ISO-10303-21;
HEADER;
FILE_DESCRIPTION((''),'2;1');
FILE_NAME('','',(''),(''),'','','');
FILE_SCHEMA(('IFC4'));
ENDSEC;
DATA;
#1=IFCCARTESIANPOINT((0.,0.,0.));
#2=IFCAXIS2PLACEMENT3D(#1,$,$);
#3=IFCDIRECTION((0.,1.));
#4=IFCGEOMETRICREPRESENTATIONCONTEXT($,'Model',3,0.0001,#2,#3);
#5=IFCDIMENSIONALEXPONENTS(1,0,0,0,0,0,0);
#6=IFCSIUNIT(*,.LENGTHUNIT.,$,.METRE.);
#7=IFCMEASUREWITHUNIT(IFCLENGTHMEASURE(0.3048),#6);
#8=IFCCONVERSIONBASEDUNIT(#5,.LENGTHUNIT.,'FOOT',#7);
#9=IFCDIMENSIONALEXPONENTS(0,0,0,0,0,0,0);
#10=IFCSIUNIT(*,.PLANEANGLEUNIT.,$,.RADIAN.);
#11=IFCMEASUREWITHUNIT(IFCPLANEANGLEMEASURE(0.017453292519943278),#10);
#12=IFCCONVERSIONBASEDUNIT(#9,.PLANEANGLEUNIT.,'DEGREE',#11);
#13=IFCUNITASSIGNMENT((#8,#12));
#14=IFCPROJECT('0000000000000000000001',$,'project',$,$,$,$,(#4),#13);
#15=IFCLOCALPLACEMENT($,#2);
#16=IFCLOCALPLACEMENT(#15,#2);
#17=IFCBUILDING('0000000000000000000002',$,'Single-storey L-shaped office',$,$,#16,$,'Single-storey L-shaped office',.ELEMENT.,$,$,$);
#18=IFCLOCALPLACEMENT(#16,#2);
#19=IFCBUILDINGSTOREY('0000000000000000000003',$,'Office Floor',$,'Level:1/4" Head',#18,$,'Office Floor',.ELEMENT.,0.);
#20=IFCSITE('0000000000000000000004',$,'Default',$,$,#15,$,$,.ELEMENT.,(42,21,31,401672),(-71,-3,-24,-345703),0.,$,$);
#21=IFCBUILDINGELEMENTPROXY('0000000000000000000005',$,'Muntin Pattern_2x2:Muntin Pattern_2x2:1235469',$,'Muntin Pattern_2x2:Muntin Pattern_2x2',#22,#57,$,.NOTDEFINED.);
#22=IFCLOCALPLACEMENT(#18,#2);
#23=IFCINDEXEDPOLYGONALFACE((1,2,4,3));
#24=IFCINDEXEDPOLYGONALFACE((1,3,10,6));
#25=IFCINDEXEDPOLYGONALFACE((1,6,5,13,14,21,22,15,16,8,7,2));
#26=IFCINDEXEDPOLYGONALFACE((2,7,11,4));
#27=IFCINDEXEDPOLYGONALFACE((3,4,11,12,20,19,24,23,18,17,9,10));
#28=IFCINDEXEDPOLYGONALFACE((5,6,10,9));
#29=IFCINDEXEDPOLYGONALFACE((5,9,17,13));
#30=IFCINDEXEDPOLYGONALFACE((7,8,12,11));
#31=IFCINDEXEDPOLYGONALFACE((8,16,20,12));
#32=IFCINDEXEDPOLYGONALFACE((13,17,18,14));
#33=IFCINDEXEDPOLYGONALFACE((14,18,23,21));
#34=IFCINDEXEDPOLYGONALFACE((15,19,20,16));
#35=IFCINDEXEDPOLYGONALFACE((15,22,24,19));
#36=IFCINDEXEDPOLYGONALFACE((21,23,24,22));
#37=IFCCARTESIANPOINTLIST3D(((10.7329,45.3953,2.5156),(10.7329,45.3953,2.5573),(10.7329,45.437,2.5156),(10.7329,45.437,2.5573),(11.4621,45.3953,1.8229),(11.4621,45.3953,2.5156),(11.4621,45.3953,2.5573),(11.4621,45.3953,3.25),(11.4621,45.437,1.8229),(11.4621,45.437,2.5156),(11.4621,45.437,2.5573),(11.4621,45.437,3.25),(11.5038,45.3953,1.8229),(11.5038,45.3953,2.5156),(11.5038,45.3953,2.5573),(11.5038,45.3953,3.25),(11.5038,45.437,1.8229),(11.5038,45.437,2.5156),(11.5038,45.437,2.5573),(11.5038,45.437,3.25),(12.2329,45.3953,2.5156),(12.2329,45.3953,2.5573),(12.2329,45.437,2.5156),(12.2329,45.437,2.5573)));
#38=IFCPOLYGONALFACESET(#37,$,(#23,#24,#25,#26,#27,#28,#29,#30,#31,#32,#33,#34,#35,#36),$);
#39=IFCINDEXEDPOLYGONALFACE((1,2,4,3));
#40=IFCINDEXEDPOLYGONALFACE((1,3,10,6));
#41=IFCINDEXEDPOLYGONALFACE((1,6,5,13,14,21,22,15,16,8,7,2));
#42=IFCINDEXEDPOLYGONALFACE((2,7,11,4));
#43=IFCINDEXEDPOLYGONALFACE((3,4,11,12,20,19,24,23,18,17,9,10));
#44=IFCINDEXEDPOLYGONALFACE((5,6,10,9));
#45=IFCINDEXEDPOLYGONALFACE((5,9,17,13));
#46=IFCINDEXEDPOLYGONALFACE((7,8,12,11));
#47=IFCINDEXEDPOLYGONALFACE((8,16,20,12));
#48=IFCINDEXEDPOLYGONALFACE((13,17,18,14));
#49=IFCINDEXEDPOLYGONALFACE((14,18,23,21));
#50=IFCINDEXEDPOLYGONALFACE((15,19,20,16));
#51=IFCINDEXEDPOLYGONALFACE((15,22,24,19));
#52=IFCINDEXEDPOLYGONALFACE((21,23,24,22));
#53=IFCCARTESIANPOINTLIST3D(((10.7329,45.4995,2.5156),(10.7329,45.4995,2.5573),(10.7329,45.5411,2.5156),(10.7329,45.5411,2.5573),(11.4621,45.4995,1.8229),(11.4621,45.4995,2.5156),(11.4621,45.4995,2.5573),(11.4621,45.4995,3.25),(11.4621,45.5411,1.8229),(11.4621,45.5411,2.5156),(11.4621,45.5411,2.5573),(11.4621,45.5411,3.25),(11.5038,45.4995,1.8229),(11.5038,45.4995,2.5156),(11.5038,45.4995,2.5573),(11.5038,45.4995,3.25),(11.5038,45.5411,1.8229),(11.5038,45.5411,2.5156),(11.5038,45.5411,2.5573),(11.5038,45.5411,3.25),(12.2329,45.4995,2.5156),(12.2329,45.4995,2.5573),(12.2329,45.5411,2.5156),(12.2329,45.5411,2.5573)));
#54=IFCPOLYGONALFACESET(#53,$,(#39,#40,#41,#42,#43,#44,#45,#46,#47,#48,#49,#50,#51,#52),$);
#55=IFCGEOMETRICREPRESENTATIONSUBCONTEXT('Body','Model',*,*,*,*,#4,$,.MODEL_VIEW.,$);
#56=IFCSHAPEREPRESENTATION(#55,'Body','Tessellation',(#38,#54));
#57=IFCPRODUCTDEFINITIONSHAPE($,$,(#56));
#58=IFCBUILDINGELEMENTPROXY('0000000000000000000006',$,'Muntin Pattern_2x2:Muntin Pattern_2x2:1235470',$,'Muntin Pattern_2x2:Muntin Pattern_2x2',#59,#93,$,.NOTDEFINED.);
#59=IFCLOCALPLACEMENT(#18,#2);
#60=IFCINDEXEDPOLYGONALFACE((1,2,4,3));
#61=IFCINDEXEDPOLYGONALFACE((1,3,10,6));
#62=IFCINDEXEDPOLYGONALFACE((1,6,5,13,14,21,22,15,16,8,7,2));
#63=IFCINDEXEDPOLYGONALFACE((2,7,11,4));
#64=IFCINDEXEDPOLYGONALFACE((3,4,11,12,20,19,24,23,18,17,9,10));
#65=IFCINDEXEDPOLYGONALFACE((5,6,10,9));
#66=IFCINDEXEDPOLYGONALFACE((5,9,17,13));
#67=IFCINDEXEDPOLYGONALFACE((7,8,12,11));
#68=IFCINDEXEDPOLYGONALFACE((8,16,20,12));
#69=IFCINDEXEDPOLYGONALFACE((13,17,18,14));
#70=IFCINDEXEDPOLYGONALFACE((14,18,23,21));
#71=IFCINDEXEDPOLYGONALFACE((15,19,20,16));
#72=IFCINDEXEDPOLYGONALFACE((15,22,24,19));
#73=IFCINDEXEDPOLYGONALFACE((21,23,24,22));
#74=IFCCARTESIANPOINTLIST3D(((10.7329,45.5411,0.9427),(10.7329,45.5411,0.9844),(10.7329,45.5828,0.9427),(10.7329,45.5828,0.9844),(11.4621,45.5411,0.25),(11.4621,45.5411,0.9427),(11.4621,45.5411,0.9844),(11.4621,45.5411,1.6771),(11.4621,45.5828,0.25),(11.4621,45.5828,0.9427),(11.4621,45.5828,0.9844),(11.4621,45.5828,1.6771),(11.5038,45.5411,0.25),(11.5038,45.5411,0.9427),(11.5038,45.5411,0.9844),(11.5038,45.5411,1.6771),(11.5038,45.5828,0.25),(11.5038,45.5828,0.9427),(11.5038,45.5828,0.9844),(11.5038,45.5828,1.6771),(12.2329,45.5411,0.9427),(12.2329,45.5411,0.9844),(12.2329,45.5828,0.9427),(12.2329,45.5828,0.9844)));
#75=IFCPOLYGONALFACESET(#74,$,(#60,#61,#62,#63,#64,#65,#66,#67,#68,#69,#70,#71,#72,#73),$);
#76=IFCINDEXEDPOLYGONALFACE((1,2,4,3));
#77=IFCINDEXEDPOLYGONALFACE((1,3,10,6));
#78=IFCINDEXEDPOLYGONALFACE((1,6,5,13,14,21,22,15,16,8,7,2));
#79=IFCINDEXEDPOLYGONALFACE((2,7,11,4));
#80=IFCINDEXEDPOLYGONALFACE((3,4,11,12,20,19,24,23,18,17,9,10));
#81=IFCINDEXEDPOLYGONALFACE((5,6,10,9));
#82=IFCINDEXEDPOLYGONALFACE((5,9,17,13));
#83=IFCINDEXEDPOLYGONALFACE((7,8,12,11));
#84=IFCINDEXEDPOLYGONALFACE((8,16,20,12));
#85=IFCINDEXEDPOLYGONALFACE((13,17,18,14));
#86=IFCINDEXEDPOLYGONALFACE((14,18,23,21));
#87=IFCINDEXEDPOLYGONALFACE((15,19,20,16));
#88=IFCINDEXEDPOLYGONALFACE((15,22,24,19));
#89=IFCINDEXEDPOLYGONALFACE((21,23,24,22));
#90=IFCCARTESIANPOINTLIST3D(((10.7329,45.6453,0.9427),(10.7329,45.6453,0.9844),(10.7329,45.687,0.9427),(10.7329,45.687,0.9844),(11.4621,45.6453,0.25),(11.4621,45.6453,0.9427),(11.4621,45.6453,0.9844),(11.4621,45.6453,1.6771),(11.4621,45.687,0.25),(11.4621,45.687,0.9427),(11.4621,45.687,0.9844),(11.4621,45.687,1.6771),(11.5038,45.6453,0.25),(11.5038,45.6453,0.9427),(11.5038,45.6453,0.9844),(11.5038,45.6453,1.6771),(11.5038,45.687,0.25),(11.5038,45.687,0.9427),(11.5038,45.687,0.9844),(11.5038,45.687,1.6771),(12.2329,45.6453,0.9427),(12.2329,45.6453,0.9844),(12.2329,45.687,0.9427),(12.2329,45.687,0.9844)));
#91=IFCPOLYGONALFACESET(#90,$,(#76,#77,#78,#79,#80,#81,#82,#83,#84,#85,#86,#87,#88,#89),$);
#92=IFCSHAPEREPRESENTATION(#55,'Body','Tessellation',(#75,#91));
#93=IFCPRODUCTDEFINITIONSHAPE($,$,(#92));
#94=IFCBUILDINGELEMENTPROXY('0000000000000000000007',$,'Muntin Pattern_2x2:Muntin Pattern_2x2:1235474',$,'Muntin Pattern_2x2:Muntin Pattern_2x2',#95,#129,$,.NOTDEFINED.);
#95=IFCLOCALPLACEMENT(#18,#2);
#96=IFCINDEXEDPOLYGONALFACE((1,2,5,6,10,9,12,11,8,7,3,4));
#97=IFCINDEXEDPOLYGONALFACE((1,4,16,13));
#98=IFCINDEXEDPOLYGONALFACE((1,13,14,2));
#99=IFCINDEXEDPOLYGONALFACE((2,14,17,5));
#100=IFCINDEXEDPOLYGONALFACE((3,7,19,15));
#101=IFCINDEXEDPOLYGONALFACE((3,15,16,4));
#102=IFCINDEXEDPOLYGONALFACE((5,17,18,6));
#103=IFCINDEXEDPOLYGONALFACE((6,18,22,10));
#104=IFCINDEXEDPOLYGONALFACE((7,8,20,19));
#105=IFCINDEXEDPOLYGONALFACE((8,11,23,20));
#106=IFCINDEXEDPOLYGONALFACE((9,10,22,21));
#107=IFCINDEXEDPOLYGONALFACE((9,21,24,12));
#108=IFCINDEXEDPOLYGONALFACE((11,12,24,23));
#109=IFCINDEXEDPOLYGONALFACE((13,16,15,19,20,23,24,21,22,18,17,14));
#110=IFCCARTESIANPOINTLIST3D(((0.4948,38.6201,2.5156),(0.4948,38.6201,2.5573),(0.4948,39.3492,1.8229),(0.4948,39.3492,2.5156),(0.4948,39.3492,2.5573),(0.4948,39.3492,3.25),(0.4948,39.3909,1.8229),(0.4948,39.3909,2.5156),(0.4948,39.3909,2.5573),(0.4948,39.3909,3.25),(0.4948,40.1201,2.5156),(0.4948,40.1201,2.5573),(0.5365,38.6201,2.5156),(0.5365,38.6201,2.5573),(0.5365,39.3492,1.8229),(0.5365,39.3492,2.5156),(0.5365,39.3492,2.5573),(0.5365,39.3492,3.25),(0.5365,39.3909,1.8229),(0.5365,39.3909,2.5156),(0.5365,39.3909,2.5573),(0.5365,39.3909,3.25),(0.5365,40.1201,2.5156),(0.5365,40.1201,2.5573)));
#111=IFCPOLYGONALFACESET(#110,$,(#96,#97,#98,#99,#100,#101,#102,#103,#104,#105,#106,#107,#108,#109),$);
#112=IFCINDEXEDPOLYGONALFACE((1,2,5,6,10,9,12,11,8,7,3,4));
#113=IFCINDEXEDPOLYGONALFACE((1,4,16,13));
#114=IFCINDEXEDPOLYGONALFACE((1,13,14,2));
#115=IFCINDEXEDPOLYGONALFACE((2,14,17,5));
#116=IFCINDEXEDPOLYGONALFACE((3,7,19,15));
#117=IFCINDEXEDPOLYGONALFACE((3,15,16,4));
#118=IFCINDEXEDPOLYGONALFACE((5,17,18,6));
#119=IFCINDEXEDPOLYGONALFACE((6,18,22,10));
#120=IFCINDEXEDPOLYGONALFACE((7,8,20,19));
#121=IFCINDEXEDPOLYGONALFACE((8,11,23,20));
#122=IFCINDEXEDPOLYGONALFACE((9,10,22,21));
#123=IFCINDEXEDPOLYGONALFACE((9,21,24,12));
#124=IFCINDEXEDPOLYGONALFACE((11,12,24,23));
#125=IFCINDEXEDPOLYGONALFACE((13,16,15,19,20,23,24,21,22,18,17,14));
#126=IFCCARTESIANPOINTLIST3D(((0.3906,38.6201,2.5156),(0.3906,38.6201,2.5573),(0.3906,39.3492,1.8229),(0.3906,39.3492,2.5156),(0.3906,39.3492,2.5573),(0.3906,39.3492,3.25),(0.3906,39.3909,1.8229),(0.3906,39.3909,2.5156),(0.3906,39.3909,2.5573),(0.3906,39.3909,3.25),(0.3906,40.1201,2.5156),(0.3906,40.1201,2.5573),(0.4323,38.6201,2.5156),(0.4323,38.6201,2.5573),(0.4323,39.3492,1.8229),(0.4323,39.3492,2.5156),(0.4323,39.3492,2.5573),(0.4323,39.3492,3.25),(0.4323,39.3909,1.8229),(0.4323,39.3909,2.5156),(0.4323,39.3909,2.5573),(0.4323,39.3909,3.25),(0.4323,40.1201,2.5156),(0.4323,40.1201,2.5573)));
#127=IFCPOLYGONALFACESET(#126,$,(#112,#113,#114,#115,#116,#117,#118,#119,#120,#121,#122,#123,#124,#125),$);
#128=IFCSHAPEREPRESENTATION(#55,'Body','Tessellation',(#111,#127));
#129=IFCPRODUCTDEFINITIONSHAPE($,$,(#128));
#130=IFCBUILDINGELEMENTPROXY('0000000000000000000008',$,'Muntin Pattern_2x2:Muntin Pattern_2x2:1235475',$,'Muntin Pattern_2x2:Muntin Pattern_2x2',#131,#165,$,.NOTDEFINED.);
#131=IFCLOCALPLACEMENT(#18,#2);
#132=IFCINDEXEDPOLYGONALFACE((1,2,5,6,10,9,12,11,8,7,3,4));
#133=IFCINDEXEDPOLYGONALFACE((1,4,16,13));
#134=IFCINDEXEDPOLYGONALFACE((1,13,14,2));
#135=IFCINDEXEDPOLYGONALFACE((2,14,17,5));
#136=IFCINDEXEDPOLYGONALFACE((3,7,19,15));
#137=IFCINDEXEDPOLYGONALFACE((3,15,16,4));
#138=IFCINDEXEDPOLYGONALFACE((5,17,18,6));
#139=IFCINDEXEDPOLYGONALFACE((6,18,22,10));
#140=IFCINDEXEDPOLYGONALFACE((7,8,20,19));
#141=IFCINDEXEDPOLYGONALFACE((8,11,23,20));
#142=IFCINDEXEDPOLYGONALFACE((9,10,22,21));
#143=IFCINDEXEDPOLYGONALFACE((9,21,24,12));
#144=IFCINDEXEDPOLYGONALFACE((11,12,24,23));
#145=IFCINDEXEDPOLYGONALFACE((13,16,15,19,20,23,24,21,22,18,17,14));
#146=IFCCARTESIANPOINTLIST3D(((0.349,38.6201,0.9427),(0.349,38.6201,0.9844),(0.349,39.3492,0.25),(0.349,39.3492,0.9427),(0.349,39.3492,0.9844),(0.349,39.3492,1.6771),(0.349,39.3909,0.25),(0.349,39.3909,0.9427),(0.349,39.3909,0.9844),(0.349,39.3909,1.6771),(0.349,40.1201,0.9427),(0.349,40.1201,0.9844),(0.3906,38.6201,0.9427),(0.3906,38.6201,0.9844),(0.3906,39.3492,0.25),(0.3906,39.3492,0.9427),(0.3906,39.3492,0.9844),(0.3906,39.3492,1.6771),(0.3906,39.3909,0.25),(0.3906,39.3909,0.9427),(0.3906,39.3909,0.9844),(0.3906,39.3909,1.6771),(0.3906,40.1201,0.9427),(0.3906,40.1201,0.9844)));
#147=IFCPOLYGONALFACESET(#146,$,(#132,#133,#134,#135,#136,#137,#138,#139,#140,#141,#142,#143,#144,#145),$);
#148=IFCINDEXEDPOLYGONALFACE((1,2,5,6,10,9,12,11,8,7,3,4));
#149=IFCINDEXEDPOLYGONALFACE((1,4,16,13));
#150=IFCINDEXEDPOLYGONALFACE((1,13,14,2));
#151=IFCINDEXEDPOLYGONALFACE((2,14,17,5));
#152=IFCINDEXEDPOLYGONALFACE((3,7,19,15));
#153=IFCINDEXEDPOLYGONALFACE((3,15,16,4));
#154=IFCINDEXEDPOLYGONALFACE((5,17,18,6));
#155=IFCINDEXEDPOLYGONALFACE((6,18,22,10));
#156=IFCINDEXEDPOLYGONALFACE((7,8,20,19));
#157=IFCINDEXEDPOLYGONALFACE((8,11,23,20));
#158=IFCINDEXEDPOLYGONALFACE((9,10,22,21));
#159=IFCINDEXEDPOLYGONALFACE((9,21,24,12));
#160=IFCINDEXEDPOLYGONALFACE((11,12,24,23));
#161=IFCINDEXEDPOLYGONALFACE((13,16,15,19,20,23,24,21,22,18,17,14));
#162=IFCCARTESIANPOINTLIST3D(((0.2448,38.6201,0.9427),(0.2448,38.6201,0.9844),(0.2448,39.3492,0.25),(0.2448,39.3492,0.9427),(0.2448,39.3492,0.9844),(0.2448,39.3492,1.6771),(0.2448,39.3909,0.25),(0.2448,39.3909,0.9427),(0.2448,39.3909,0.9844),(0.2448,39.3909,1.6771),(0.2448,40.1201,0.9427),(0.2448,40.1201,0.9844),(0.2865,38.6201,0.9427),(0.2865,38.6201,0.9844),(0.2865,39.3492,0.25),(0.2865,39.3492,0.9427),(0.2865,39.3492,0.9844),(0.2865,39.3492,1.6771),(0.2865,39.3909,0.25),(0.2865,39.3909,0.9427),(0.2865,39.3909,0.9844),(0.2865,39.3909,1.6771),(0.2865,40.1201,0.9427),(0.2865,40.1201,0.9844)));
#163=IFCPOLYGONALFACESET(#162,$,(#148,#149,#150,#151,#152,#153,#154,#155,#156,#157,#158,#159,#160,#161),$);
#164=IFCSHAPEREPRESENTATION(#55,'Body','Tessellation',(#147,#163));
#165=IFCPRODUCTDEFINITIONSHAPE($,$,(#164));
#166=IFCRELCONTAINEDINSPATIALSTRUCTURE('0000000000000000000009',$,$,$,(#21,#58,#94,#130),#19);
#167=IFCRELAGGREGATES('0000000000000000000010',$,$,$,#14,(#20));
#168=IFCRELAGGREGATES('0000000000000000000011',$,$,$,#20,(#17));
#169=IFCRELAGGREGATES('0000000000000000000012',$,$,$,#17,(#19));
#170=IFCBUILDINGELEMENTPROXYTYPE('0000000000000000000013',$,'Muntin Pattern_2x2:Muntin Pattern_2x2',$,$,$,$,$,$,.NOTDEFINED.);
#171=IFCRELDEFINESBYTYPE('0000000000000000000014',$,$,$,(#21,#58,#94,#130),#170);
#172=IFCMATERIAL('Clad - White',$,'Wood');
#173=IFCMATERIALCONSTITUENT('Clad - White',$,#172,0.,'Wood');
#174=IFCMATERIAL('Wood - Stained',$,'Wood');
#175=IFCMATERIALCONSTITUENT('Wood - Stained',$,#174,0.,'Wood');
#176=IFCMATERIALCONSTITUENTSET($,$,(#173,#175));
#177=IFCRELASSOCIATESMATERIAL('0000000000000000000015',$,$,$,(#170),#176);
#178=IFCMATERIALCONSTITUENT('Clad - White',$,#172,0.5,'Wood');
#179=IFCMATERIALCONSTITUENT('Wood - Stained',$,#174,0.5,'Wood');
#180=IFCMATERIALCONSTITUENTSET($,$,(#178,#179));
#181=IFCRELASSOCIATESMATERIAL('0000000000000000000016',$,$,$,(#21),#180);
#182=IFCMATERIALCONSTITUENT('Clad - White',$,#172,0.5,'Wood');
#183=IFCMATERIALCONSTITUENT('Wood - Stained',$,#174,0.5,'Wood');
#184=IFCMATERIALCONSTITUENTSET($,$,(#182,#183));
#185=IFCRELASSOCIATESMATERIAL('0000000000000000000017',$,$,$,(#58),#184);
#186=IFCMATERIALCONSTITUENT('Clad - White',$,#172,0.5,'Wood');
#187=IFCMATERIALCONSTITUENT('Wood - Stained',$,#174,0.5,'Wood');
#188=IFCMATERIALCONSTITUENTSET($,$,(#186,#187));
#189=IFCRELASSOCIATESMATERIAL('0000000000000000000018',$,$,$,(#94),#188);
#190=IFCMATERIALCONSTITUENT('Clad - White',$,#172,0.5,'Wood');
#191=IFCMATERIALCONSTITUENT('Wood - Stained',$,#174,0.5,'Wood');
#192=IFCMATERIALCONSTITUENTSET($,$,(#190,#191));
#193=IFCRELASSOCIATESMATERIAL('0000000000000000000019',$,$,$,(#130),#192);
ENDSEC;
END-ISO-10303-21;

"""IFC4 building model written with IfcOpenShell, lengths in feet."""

from ifc_helpers import new_model, entity, si_unit, converted_unit, direction, frame, origin, place, context, subcontext, project, spatial, indexed_curve, outline, extrude, source, transform, mapped, material, constituent, constituent_set, type_object, type_shapes, element, save


model = new_model("IFC4")

# Units and contexts
model_context = context("Model", 3, precision=0.0001, world=origin(), true_north=direction((0.0, 1.0)))
body_context = subcontext(model_context, "Body", "Model", "MODEL_VIEW")
ifc_project = project(units=[converted_unit("LENGTHUNIT", "FOOT", entity("IfcLengthMeasure", 0.3048), si_unit("LENGTHUNIT", "METRE"), dimensions=[1, 0, 0, 0, 0, 0, 0]), converted_unit("PLANEANGLEUNIT", "DEGREE", entity("IfcPlaneAngleMeasure", 0.017453292519943278), si_unit("PLANEANGLEUNIT", "RADIAN"), dimensions=[0, 0, 0, 0, 0, 0, 0])], contexts=[model_context])

# Site, building, storey
site_placement = place(None, origin())
site = spatial("IfcSite", under=ifc_project, at=site_placement, Name="Default", CompositionType="ELEMENT", RefLatitude=(42, 21, 31, 401672), RefLongitude=(-71, -3, -24, -345703), RefElevation=0.0)
building_placement = place(site_placement, origin())
building = spatial("IfcBuilding", under=site, at=building_placement, Name="Single-storey L-shaped office", LongName="Single-storey L-shaped office", CompositionType="ELEMENT")
storey_placement = place(building_placement, origin())
storey = spatial("IfcBuildingStorey", under=building, at=storey_placement, Name="Office Floor", ObjectType="Level:1/4\" Head", LongName="Office Floor", CompositionType="ELEMENT", Elevation=0.0)

# Shared definitions
ifc_material_1 = material(Name="Wood - Stained", Category="Wood")

# Building element proxies
ifc_material_2 = material(Name="Clad - White", Category="Wood")
ifc_constituent_1 = constituent(ifc_material_2, Name="Clad - White", Category="Wood", fraction=0.0)
ifc_constituent_2 = constituent(ifc_material_1, Name="Wood - Stained", Category="Wood", fraction=0.0)
ifc_constituent_set_1 = constituent_set(constituents=[ifc_constituent_1, ifc_constituent_2])
building_element_proxy_type_1 = type_object("IfcBuildingElementProxyType", Name="Muntin Pattern_2x2:Muntin Pattern_2x2", PredefinedType="NOTDEFINED", material=ifc_constituent_set_1)
shared_shape_1 = source(origin(), body_context, "Body", "SweptSolid", [
    extrude(outline(indexed_curve([(0.0208, -0.0208), (0.7135, -0.0208), (0.7135, 0.0208), (0.0208, 0.0208), (0.0208, 0.75), (-0.0208, 0.75), (-0.0208, 0.0208), (-0.7135, 0.0208), (-0.7135, -0.0208), (-0.0208, -0.0208), (-0.0208, -0.75), (0.0208, -0.75), (0.0208, -0.0208)], self_intersect=False)), frame((0.0, 0.0312, 0.7135), z_axis=(0.0, 1.0, 0.0), x_axis=(0.0, 0.0, 1.0)), (0.0, 0.0, 1.0), 0.0417),
    extrude(outline(indexed_curve([(0.0208, -0.0208), (0.7135, -0.0208), (0.7135, 0.0208), (0.0208, 0.0208), (0.0208, 0.75), (-0.0208, 0.75), (-0.0208, 0.0208), (-0.7135, 0.0208), (-0.7135, -0.0208), (-0.0208, -0.0208), (-0.0208, -0.75), (0.0208, -0.75), (0.0208, -0.0208)], self_intersect=False)), frame((0.0, -0.0729, 0.7135), z_axis=(0.0, 1.0, 0.0), x_axis=(0.0, 0.0, 1.0)), (0.0, 0.0, 1.0), 0.0417),
])
type_shapes(building_element_proxy_type_1, [shared_shape_1])
ifc_constituent_3 = constituent(ifc_material_2, Name="Clad - White", Category="Wood", fraction=0.5)
ifc_constituent_4 = constituent(ifc_material_1, Name="Wood - Stained", Category="Wood", fraction=0.5)
ifc_constituent_set_2 = constituent_set(constituents=[ifc_constituent_3, ifc_constituent_4])
proxy_1_placement = place(storey_placement, frame((11.4829, 45.4682, 1.8229), z_axis=(0.0, 0.0, 1.0), x_axis=(-1.0, 0.0, 0.0)))
element("IfcBuildingElementProxy", 1, at=proxy_1_placement, inside=storey, type_object=building_element_proxy_type_1, material=ifc_constituent_set_2, Name="Muntin Pattern_2x2:Muntin Pattern_2x2:1235469", ObjectType="Muntin Pattern_2x2:Muntin Pattern_2x2", PredefinedType="NOTDEFINED", context=body_context, shape_type="MappedRepresentation", body=[
    mapped(shared_shape_1, transform((0.0, 0.0, 0.0), scale=1.0)),
])
ifc_constituent_5 = constituent(ifc_material_2, Name="Clad - White", Category="Wood", fraction=0.5)
ifc_constituent_6 = constituent(ifc_material_1, Name="Wood - Stained", Category="Wood", fraction=0.5)
ifc_constituent_set_3 = constituent_set(constituents=[ifc_constituent_5, ifc_constituent_6])
proxy_2_placement = place(storey_placement, frame((11.4829, 45.6141, 0.25), z_axis=(0.0, 0.0, 1.0), x_axis=(-1.0, 0.0, 0.0)))
element("IfcBuildingElementProxy", 2, at=proxy_2_placement, inside=storey, type_object=building_element_proxy_type_1, material=ifc_constituent_set_3, Name="Muntin Pattern_2x2:Muntin Pattern_2x2:1235470", ObjectType="Muntin Pattern_2x2:Muntin Pattern_2x2", PredefinedType="NOTDEFINED", context=body_context, shape_type="MappedRepresentation", body=[
    mapped(shared_shape_1, transform((0.0, 0.0, 0.0), scale=1.0)),
])
ifc_constituent_7 = constituent(ifc_material_2, Name="Clad - White", Category="Wood", fraction=0.5)
ifc_constituent_8 = constituent(ifc_material_1, Name="Wood - Stained", Category="Wood", fraction=0.5)
ifc_constituent_set_4 = constituent_set(constituents=[ifc_constituent_7, ifc_constituent_8])
proxy_3_placement = place(storey_placement, frame((0.4635, 39.3701, 1.8229), z_axis=(0.0, 0.0, 1.0), x_axis=(0.0, -1.0, 0.0)))
element("IfcBuildingElementProxy", 3, at=proxy_3_placement, inside=storey, type_object=building_element_proxy_type_1, material=ifc_constituent_set_4, Name="Muntin Pattern_2x2:Muntin Pattern_2x2:1235474", ObjectType="Muntin Pattern_2x2:Muntin Pattern_2x2", PredefinedType="NOTDEFINED", context=body_context, shape_type="MappedRepresentation", body=[
    mapped(shared_shape_1, transform((0.0, 0.0, 0.0), scale=1.0)),
])
ifc_constituent_9 = constituent(ifc_material_2, Name="Clad - White", Category="Wood", fraction=0.5)
ifc_constituent_10 = constituent(ifc_material_1, Name="Wood - Stained", Category="Wood", fraction=0.5)
ifc_constituent_set_5 = constituent_set(constituents=[ifc_constituent_9, ifc_constituent_10])
proxy_4_placement = place(storey_placement, frame((0.3177, 39.3701, 0.25), z_axis=(0.0, 0.0, 1.0), x_axis=(0.0, -1.0, 0.0)))
element("IfcBuildingElementProxy", 4, at=proxy_4_placement, inside=storey, type_object=building_element_proxy_type_1, material=ifc_constituent_set_5, Name="Muntin Pattern_2x2:Muntin Pattern_2x2:1235475", ObjectType="Muntin Pattern_2x2:Muntin Pattern_2x2", PredefinedType="NOTDEFINED", context=body_context, shape_type="MappedRepresentation", body=[
    mapped(shared_shape_1, transform((0.0, 0.0, 0.0), scale=1.0)),
])

save(model, "model.ifc")
